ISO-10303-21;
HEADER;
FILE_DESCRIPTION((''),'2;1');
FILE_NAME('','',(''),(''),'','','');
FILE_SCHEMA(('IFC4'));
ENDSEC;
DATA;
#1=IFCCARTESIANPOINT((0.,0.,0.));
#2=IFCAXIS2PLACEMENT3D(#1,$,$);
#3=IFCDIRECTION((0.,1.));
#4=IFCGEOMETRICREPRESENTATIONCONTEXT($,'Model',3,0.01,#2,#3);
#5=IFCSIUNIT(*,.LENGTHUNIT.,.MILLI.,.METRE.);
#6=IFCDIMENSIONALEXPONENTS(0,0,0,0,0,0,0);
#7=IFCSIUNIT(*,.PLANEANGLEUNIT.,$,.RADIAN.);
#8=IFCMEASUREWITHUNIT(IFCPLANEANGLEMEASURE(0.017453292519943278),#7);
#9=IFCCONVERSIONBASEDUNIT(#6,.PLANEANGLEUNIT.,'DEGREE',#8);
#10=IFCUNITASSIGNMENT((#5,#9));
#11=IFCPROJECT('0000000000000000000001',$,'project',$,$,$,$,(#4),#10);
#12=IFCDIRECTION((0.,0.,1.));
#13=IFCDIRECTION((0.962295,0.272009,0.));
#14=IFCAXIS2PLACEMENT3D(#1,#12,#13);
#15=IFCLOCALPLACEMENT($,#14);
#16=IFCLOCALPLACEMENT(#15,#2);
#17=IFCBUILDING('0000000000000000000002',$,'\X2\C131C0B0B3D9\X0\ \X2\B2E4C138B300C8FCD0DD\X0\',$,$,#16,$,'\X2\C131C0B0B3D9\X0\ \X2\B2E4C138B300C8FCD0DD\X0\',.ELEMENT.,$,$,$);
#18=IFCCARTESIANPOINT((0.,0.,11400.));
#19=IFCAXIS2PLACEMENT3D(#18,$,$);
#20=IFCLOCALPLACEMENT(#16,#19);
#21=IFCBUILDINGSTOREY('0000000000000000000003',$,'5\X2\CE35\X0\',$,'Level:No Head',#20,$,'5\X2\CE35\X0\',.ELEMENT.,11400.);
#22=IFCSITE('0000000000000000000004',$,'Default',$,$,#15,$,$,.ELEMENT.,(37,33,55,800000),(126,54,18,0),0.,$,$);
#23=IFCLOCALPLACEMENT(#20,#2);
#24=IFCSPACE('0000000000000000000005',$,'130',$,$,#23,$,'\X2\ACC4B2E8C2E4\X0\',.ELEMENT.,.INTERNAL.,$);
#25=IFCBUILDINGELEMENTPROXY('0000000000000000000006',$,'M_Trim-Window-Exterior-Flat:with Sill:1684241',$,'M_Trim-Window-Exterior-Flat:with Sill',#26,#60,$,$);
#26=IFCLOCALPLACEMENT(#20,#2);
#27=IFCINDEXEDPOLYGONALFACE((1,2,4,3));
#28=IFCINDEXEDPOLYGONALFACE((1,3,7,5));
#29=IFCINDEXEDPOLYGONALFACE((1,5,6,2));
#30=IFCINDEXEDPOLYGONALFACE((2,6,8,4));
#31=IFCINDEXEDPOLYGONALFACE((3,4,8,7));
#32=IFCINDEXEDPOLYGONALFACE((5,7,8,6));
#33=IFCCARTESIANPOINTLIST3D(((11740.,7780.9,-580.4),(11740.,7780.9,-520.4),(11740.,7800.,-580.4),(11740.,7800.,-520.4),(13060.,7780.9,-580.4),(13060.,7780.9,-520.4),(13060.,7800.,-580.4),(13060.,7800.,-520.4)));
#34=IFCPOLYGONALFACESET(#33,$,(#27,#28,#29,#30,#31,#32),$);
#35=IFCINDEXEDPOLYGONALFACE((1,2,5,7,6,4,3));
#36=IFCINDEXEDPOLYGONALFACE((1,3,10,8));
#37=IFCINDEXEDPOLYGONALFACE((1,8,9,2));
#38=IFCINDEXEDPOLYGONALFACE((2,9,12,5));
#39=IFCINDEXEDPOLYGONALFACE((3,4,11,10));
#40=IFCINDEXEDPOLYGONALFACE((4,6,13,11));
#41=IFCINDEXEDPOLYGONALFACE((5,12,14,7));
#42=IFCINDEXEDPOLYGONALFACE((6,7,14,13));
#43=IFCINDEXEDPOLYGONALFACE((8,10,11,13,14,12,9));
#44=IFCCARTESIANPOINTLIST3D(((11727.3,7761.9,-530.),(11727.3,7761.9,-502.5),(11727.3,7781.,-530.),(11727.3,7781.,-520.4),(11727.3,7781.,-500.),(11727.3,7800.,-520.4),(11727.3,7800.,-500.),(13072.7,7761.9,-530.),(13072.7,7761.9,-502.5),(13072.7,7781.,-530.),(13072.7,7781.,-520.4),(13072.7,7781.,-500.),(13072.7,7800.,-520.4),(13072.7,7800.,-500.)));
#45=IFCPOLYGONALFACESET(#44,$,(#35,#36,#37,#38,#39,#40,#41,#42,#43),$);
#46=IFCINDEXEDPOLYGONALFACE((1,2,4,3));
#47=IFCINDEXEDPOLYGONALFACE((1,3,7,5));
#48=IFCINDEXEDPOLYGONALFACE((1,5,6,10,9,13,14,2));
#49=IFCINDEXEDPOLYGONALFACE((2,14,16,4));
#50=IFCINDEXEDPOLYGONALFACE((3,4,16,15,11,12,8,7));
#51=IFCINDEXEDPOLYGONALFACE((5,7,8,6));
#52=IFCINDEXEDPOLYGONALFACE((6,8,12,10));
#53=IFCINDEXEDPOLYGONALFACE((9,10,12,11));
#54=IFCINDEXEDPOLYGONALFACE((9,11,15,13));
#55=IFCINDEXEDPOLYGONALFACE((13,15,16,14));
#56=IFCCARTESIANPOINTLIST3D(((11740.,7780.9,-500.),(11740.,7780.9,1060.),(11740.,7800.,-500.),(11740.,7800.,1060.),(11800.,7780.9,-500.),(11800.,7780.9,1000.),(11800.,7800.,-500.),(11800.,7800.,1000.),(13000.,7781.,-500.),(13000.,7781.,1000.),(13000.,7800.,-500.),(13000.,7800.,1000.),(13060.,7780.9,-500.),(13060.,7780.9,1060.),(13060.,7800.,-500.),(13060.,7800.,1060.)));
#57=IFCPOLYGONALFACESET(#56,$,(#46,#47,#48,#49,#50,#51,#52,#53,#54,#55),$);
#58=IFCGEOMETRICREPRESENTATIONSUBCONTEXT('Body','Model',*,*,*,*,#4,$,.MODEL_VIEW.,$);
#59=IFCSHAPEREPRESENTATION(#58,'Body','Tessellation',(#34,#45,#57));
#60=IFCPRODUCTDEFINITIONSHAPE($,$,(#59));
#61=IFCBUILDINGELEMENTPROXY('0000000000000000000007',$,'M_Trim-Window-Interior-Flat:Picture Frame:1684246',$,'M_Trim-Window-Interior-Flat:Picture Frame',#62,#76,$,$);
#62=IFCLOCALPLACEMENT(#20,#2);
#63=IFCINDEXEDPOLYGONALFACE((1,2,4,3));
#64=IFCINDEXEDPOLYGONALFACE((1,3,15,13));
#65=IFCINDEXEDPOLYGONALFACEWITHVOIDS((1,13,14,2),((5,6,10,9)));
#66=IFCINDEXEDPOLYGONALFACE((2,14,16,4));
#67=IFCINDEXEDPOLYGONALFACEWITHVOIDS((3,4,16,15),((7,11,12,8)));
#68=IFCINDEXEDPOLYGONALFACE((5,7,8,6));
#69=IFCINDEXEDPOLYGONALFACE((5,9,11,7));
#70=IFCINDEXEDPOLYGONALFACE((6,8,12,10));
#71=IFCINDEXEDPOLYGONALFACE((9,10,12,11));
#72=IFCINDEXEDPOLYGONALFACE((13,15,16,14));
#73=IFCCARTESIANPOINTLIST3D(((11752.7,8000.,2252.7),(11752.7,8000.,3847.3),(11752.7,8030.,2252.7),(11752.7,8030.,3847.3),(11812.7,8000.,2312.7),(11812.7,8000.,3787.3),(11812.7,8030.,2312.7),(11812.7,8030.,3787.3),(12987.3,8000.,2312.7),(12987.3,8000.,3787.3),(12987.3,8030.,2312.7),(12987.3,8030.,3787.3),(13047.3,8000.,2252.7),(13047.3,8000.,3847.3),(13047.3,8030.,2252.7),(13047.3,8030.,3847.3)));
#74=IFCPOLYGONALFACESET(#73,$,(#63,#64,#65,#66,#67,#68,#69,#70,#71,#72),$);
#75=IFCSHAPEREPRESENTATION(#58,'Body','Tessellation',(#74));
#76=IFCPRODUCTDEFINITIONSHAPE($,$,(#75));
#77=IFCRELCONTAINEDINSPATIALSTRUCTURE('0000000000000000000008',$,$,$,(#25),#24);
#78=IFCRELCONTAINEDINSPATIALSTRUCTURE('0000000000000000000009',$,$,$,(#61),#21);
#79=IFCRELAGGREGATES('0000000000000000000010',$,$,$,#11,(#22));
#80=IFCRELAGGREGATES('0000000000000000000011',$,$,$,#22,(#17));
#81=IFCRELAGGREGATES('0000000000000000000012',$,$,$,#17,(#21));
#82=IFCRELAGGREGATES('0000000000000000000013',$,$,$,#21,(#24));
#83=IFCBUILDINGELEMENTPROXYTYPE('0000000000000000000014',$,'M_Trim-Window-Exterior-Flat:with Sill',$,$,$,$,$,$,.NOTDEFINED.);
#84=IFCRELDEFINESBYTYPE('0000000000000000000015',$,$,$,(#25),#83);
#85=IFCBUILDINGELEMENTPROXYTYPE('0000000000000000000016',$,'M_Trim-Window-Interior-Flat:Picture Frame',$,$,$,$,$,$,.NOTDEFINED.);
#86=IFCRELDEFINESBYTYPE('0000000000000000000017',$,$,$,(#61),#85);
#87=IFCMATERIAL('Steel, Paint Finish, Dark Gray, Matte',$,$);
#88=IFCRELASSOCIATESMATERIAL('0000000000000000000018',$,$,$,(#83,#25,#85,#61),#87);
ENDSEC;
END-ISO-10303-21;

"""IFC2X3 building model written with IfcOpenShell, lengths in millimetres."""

from ifc_helpers import new_model, entity, si_unit, converted_unit, direction, frame, frame_2d, origin, place, context, subcontext, project, spatial, polyline, rectangle, outline, extrude, source, transform, mapped, material, type_object, type_shapes, element, save


model = new_model("IFC2X3")

# Units and contexts
model_context = context("Model", 3, precision=0.01, world=origin(), true_north=direction((0.0, 1.0)))
body_context = subcontext(model_context, "Body", "Model", "MODEL_VIEW")
ifc_project = project(units=[si_unit("LENGTHUNIT", "METRE", prefix="MILLI"), converted_unit("PLANEANGLEUNIT", "DEGREE", entity("IfcPlaneAngleMeasure", 0.017453292519943278), si_unit("PLANEANGLEUNIT", "RADIAN"), dimensions=[0, 0, 0, 0, 0, 0, 0])], contexts=[model_context])

# Site, building, storey
site_placement = place(None, frame((0.0, 0.0, 0.0), z_axis=(0.0, 0.0, 1.0), x_axis=(0.962295, 0.272009, 0.0)))
site = spatial("IfcSite", under=ifc_project, at=site_placement, Name="Default", CompositionType="ELEMENT", RefLatitude=(37, 33, 55, 800000), RefLongitude=(126, 54, 18, 0), RefElevation=0.0)
building_placement = place(site_placement, origin())
building = spatial("IfcBuilding", under=site, at=building_placement, Name="성산동 다세대주택", LongName="성산동 다세대주택", CompositionType="ELEMENT")
storey_placement = place(building_placement, frame((0.0, 0.0, 11400.0)))
storey = spatial("IfcBuildingStorey", under=building, at=storey_placement, Name="5층", ObjectType="Level:No Head", LongName="5층", CompositionType="ELEMENT", Elevation=11400.0)

# Shared definitions
ifc_material_1 = material(Name="Steel, Paint Finish, Dark Gray, Matte")

# Shared definitions
space_1_placement = place(storey_placement, origin())
space_1 = spatial("IfcSpace", under=storey, at=space_1_placement, Name="130", LongName="계단실", CompositionType="ELEMENT", InteriorOrExteriorSpace="INTERNAL")

# Building element proxies
building_element_proxy_type_1 = type_object("IfcBuildingElementProxyType", Name="M_Trim-Window-Exterior-Flat:with Sill", PredefinedType="NOTDEFINED", material=ifc_material_1)
shared_shape_1 = source(origin(), body_context, "Body", "SweptSolid", [
    extrude(rectangle(XDim=1320.0, YDim=60.0, at=frame_2d((0.0, 0.0), x_axis=(1.0, 0.0))), frame((0.0, -1550.4, 0.0), z_axis=(0.0, 0.0, 1.0), x_axis=(-1.0, 0.0, 0.0)), (0.0, 0.0, 1.0), 19.0),
    extrude(outline(polyline([(-19.0, -15.2), (0.0, -15.2), (0.0, -5.7), (19.0, -5.7), (19.0, 14.8), (0.0, 14.8), (-19.0, 12.3), (-19.0, -15.2)])), frame((-672.7, -1514.8, 19.0), z_axis=(1.0, 0.0, 0.0), x_axis=(0.0, 0.0, -1.0)), (0.0, 0.0, 1.0), 1345.4),
    extrude(outline(polyline([(-795.0, -660.0), (765.0, -660.0), (765.0, -600.0), (-735.0, -600.0), (-735.0, 600.0), (765.0, 600.0), (765.0, 660.0), (-795.0, 660.0), (-795.0, -660.0)])), frame((0.0, -735.0, 0.0), z_axis=(0.0, 0.0, 1.0), x_axis=(0.0, -1.0, 0.0)), (0.0, 0.0, 1.0), 19.0),
])
type_shapes(building_element_proxy_type_1, [shared_shape_1])
proxy_1_placement = place(space_1_placement, frame((12400.0, 7800.0, 1000.0), z_axis=(0.0, -1.0, 0.0), x_axis=(1.0, 0.0, 0.0)))
element("IfcBuildingElementProxy", 1, at=proxy_1_placement, inside=space_1, type_object=building_element_proxy_type_1, material=ifc_material_1, Name="M_Trim-Window-Exterior-Flat:with Sill:1684241", ObjectType="M_Trim-Window-Exterior-Flat:with Sill", context=body_context, shape_type="MappedRepresentation", body=[
    mapped(shared_shape_1, transform((0.0, 0.0, 0.0), scale=1.0)),
])
building_element_proxy_type_2 = type_object("IfcBuildingElementProxyType", Name="M_Trim-Window-Interior-Flat:Picture Frame", PredefinedType="NOTDEFINED", material=ifc_material_1)
shared_shape_2 = source(origin(), body_context, "Body", "SweptSolid", [
    extrude(outline(polyline([(-647.3, -797.3), (647.3, -797.3), (647.3, 797.3), (-647.3, 797.3), (-647.3, -797.3)]), holes=[polyline([(-587.3, -737.3), (-587.3, 737.3), (587.3, 737.3), (587.3, -737.3), (-587.3, -737.3)])]), frame((0.0, -750.0, 0.0), z_axis=(0.0, 0.0, 1.0), x_axis=(-1.0, 0.0, 0.0)), (0.0, 0.0, 1.0), 30.0),
])
type_shapes(building_element_proxy_type_2, [shared_shape_2])
proxy_2_placement = place(storey_placement, frame((12400.0, 8000.0, 3800.0), z_axis=(0.0, 1.0, 0.0), x_axis=(-1.0, 0.0, 0.0)))
element("IfcBuildingElementProxy", 2, at=proxy_2_placement, inside=storey, type_object=building_element_proxy_type_2, material=ifc_material_1, Name="M_Trim-Window-Interior-Flat:Picture Frame:1684246", ObjectType="M_Trim-Window-Interior-Flat:Picture Frame", context=body_context, shape_type="MappedRepresentation", body=[
    mapped(shared_shape_2, transform((0.0, 0.0, 0.0), scale=1.0)),
])

save(model, "model.ifc")
